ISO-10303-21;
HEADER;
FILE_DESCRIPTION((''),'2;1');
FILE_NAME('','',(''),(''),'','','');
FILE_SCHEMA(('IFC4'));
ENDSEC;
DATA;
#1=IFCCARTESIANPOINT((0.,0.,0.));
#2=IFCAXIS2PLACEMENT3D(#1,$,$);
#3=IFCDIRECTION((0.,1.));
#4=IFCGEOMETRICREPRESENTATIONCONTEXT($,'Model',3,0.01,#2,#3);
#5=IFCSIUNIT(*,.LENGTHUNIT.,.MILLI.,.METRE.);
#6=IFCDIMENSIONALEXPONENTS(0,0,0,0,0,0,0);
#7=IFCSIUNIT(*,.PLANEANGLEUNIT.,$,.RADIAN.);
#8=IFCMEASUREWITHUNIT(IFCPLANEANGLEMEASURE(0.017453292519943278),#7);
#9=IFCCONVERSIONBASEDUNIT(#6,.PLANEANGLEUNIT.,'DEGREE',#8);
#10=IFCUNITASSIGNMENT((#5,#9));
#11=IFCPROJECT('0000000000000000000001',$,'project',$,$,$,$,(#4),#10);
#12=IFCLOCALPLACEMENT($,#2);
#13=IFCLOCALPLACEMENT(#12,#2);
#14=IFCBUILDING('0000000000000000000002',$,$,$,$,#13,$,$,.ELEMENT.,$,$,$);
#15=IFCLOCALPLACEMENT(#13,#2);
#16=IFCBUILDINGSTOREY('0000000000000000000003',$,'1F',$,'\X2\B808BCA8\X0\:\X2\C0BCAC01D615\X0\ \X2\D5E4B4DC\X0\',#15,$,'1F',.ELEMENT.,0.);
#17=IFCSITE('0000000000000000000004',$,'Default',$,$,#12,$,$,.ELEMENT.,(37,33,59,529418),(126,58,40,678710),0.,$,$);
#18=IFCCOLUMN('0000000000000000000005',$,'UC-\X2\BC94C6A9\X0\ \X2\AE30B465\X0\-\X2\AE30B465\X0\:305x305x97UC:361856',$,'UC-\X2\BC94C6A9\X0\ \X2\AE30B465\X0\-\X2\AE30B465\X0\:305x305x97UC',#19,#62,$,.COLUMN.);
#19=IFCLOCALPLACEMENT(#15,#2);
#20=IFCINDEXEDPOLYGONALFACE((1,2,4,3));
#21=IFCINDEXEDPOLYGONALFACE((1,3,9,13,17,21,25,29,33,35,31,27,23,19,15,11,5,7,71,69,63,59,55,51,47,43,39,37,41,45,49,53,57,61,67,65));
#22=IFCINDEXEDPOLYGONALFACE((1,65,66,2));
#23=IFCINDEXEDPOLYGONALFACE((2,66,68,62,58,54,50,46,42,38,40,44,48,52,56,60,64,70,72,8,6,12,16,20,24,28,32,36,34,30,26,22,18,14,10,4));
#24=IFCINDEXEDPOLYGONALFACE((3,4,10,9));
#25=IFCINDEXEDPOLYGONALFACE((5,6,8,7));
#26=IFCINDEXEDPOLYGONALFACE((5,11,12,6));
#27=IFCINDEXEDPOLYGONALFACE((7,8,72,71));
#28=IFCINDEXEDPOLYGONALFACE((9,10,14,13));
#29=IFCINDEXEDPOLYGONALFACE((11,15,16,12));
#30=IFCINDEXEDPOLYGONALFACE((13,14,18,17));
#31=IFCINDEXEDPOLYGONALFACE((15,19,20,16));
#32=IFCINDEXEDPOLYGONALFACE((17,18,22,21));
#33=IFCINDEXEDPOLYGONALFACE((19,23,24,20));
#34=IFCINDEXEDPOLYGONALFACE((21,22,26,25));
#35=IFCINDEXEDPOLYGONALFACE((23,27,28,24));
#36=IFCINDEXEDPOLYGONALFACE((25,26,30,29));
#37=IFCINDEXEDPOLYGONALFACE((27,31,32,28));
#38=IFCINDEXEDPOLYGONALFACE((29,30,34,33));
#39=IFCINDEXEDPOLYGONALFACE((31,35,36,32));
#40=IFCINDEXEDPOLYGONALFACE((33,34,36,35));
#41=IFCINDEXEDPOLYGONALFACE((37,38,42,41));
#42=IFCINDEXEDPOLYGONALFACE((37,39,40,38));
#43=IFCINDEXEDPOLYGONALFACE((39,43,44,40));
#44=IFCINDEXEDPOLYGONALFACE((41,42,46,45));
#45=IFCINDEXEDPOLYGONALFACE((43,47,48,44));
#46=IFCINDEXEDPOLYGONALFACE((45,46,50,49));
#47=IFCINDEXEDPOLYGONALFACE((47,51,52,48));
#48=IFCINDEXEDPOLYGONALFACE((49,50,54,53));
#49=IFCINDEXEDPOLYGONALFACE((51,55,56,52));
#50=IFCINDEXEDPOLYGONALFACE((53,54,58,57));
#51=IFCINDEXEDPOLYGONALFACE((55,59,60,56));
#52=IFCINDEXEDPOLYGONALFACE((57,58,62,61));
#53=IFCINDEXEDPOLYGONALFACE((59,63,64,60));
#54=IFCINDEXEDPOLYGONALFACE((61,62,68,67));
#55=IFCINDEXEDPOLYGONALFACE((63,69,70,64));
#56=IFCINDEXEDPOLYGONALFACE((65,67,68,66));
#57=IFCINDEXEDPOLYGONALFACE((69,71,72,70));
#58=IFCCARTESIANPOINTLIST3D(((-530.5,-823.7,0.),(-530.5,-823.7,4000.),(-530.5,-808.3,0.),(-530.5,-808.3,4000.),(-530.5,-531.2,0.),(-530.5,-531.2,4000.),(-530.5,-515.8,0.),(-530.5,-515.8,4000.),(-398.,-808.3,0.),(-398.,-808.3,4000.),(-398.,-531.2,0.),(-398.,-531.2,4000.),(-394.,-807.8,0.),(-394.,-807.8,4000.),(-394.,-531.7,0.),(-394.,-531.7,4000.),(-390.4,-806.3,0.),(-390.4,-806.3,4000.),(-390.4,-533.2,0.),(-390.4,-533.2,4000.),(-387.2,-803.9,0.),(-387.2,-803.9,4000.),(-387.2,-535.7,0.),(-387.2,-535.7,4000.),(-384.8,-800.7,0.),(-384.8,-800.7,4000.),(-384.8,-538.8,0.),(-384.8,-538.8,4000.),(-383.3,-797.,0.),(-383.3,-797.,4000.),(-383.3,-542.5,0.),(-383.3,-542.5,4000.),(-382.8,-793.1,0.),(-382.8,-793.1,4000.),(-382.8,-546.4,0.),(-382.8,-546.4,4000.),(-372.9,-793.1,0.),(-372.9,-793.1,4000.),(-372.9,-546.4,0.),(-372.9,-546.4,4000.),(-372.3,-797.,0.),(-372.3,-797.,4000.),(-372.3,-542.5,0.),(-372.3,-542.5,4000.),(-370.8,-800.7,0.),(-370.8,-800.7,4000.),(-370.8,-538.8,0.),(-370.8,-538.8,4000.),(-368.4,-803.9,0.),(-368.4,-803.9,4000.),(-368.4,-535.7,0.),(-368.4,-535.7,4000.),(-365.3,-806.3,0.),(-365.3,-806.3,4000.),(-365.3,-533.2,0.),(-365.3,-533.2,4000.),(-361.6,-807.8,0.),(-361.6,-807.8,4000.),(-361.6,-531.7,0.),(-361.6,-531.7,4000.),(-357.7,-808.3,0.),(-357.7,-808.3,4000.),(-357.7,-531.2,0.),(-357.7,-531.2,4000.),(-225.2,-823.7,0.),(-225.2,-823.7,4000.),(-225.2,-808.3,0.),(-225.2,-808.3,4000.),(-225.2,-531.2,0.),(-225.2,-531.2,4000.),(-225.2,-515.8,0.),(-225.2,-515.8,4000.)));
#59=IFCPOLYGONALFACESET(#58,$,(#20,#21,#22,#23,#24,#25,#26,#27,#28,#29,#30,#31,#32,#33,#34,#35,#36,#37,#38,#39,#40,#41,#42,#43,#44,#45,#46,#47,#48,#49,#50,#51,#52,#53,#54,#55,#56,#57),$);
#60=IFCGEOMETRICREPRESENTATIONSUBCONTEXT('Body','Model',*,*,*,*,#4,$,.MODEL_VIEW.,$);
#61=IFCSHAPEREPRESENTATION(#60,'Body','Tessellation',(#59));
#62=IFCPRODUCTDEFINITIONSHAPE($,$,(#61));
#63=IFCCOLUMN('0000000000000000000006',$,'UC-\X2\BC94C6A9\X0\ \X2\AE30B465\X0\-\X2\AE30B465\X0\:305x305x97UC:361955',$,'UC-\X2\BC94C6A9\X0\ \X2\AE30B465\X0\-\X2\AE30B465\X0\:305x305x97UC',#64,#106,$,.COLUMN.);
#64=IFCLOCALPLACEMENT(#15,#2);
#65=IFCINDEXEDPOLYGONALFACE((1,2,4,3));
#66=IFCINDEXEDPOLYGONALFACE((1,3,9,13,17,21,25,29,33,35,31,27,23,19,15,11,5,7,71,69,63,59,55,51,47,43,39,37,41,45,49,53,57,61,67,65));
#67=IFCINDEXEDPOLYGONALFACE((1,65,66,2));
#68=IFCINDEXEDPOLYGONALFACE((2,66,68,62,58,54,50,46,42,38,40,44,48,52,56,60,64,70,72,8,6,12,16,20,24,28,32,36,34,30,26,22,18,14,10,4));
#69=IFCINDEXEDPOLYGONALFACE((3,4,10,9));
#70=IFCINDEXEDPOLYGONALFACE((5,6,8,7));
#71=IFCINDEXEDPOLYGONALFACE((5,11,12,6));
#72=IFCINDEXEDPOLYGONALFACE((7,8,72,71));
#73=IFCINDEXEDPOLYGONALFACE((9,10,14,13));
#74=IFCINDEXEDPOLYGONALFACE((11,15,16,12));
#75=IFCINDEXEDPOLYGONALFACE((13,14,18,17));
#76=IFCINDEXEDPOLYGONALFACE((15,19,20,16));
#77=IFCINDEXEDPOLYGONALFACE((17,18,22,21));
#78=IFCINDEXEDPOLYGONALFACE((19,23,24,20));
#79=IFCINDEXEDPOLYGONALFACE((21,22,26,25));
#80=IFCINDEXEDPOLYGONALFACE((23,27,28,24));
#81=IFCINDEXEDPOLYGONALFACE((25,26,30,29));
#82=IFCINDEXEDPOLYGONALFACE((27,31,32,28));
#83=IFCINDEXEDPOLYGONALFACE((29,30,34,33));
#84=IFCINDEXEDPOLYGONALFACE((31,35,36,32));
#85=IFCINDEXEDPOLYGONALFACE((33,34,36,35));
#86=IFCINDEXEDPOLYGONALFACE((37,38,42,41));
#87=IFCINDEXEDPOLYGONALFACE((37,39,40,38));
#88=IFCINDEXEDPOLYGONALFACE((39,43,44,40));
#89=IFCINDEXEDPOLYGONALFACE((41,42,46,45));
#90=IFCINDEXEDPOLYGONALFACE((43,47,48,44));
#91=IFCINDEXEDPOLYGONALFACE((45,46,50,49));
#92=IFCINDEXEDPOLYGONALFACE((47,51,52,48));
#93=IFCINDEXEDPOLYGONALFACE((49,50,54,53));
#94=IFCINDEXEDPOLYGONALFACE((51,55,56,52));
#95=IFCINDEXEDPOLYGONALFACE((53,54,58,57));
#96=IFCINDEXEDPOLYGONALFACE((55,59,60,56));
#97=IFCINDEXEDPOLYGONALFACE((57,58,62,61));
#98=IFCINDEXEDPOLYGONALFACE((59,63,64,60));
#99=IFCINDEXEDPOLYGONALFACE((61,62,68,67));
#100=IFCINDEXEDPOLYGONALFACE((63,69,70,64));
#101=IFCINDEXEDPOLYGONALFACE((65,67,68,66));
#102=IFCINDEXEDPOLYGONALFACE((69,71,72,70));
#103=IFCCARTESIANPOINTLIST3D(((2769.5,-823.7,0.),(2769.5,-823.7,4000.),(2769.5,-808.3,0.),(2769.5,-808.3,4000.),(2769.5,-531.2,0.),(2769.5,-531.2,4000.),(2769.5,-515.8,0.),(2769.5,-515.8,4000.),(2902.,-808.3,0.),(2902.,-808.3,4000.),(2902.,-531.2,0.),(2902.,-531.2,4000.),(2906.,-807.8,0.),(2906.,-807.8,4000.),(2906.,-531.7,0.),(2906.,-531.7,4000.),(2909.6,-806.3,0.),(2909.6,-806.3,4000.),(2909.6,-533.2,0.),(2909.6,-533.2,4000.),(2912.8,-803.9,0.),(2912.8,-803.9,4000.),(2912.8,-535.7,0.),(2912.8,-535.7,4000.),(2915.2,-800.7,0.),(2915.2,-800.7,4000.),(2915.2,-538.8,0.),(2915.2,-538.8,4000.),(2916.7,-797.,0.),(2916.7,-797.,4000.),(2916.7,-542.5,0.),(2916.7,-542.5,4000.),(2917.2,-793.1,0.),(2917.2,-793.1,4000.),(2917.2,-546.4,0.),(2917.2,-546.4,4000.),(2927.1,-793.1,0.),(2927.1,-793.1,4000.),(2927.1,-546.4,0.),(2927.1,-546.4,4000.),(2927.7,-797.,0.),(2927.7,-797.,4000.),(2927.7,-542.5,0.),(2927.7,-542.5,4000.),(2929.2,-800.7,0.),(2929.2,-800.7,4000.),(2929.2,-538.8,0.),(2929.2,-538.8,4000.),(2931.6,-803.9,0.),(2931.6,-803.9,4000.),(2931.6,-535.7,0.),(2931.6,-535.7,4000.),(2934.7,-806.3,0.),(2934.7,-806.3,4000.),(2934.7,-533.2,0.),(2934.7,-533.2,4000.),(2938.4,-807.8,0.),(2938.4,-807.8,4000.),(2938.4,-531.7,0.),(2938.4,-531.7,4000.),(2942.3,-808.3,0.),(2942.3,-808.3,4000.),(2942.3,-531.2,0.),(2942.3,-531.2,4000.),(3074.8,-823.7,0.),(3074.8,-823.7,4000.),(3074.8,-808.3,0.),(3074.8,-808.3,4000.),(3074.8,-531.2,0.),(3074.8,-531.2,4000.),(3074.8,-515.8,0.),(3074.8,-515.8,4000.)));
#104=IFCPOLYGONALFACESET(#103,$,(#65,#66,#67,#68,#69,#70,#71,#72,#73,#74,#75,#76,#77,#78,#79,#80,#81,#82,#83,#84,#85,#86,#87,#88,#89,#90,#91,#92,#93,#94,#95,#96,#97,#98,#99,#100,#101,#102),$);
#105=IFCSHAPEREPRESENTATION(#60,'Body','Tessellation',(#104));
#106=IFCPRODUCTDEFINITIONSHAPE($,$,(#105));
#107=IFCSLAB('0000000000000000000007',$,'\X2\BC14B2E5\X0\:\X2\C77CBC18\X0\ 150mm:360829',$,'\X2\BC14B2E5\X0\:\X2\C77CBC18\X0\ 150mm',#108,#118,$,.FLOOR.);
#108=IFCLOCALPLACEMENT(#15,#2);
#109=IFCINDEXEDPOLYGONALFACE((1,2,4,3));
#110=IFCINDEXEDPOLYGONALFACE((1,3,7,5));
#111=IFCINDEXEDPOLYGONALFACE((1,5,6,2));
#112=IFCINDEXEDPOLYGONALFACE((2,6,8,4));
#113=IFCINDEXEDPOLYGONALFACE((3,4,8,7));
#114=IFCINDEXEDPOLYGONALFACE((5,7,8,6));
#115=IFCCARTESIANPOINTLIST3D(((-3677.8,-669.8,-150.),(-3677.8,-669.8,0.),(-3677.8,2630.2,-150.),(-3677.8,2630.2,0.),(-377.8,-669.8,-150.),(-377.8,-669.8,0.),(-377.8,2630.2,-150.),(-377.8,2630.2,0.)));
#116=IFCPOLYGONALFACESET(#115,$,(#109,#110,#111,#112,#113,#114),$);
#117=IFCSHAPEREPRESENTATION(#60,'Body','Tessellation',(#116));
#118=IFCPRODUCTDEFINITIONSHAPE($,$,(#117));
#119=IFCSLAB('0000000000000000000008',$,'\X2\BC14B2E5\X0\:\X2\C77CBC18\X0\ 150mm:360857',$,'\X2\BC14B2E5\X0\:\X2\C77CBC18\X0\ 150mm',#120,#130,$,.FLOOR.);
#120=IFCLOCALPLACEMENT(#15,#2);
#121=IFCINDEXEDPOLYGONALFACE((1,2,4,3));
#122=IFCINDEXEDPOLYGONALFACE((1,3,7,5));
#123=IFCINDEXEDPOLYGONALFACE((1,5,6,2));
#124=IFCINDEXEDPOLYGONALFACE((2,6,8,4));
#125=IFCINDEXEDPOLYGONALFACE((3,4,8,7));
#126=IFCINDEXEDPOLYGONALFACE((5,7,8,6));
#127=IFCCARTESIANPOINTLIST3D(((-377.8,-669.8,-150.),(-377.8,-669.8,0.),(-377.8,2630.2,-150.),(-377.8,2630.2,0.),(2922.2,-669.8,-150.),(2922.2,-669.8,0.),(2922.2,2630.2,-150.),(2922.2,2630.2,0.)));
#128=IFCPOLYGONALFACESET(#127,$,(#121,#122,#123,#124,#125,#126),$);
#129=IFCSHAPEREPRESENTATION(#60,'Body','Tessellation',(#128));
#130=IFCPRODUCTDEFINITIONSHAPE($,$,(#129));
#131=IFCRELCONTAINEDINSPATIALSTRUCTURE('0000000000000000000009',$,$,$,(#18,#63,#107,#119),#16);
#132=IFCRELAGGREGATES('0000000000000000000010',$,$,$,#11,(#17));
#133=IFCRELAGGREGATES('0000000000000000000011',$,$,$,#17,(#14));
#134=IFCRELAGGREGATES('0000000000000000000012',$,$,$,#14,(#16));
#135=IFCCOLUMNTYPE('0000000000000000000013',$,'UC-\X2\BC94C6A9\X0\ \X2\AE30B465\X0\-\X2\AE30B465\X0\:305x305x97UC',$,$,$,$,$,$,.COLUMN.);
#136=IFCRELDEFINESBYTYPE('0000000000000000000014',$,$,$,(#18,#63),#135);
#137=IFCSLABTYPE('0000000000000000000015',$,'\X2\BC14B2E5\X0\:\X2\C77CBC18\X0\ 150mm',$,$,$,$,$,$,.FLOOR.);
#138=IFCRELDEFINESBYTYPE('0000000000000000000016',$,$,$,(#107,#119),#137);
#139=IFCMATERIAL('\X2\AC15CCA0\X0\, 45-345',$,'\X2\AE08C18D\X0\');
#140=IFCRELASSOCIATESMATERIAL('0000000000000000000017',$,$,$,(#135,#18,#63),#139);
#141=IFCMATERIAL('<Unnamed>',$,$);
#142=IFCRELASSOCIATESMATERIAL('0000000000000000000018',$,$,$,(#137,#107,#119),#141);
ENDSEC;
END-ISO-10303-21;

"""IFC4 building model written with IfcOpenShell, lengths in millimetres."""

from ifc_helpers import new_model, entity, si_unit, converted_unit, direction, frame, origin, place, context, subcontext, project, spatial, line, arc, indexed_curve, outline, extrude, source, transform, mapped, material, type_object, type_shapes, element, save


model = new_model("IFC4")

# Units and contexts
model_context = context("Model", 3, precision=0.01, world=origin(), true_north=direction((0.0, 1.0)))
body_context = subcontext(model_context, "Body", "Model", "MODEL_VIEW")
ifc_project = project(units=[si_unit("LENGTHUNIT", "METRE", prefix="MILLI"), converted_unit("PLANEANGLEUNIT", "DEGREE", entity("IfcPlaneAngleMeasure", 0.017453292519943278), si_unit("PLANEANGLEUNIT", "RADIAN"), dimensions=[0, 0, 0, 0, 0, 0, 0])], contexts=[model_context])

# Site, building, storey
site_placement = place(None, origin())
site = spatial("IfcSite", under=ifc_project, at=site_placement, Name="Default", CompositionType="ELEMENT", RefLatitude=(37, 33, 59, 529418), RefLongitude=(126, 58, 40, 678710), RefElevation=0.0)
building_placement = place(site_placement, origin())
building = spatial("IfcBuilding", under=site, at=building_placement, CompositionType="ELEMENT")
storey_placement = place(building_placement, origin())
storey = spatial("IfcBuildingStorey", under=building, at=storey_placement, Name="1F", ObjectType="레벨:삼각형 헤드", LongName="1F", CompositionType="ELEMENT", Elevation=0.0)

# Columns
ifc_material_1 = material(Name="강철, 45-345", Category="금속")
column_type = type_object("IfcColumnType", Name="UC-범용 기둥-기둥:305x305x97UC", PredefinedType="COLUMN", material=ifc_material_1)
shared_shape = source(origin(), body_context, "Body", "SweptSolid", [
    extrude(outline(indexed_curve([(-152.6, -153.9), (152.6, -153.9), (152.6, -138.5), (20.2, -138.5), (9.4, -134.1), (5.0, -123.3), (5.0, 123.3), (9.4, 134.1), (20.2, 138.5), (152.6, 138.5), (152.6, 153.9), (-152.6, 153.9), (-152.6, 138.5), (-20.2, 138.5), (-9.4, 134.1), (-5.0, 123.4), (-5.0, -123.3), (-9.4, -134.1), (-20.2, -138.5), (-152.6, -138.5)], segments=[line(1, 2, 3, 4), arc(4, 5, 6), line(6, 7), arc(7, 8, 9), line(9, 10, 11, 12, 13, 14), arc(14, 15, 16), line(16, 17), arc(17, 18, 19), line(19, 20, 1)], self_intersect=False)), frame((0.0, 0.0, 0.0), z_axis=(0.0, 0.0, 1.0), x_axis=(-1.0, 0.0, 0.0)), (0.0, 0.0, 1.0), 4000.0),
])
type_shapes(column_type, [shared_shape])
for number, where, name in (
    (1, (-377.8, -669.8, 0.0), "UC-범용 기둥-기둥:305x305x97UC:361856"),
    (2, (2922.2, -669.8, 0.0), "UC-범용 기둥-기둥:305x305x97UC:361955"),
):
    element("IfcColumn", number, at=place(storey_placement, frame(where)), inside=storey, type_object=column_type, material=ifc_material_1, Name=name, ObjectType="UC-범용 기둥-기둥:305x305x97UC", PredefinedType="COLUMN", context=body_context, shape_type="MappedRepresentation", body=[
        mapped(shared_shape, transform((0.0, 0.0, 0.0), scale=1.0)),
    ])

# Slabs
ifc_material_2 = material(Name="<Unnamed>")
slab_type = type_object("IfcSlabType", Name="바닥:일반 150mm", PredefinedType="FLOOR", material=ifc_material_2)
slab_1_placement = place(storey_placement, origin())
element("IfcSlab", 3, at=slab_1_placement, inside=storey, type_object=slab_type, material=ifc_material_2, Name="바닥:일반 150mm:360829", ObjectType="바닥:일반 150mm", PredefinedType="FLOOR", context=body_context, shape_type="SweptSolid", body=[
    extrude(outline(indexed_curve([(-1650.0, -1650.0), (1650.0, -1650.0), (1650.0, 1650.0), (-1650.0, 1650.0), (-1650.0, -1650.0)], self_intersect=False)), frame((-2027.8, 980.2, 0.0), z_axis=(0.0, 0.0, -1.0), x_axis=(0.0, 1.0, 0.0)), (0.0, 0.0, 1.0), 150.0),
])
slab_2_placement = place(storey_placement, origin())
element("IfcSlab", 4, at=slab_2_placement, inside=storey, type_object=slab_type, material=ifc_material_2, Name="바닥:일반 150mm:360857", ObjectType="바닥:일반 150mm", PredefinedType="FLOOR", context=body_context, shape_type="SweptSolid", body=[
    extrude(outline(indexed_curve([(-1650.0, -1650.0), (1650.0, -1650.0), (1650.0, 1650.0), (-1650.0, 1650.0), (-1650.0, -1650.0)], self_intersect=False)), frame((1272.2, 980.2, 0.0), z_axis=(0.0, 0.0, -1.0), x_axis=(0.0, 1.0, 0.0)), (0.0, 0.0, 1.0), 150.0),
])

save(model, "model.ifc")
